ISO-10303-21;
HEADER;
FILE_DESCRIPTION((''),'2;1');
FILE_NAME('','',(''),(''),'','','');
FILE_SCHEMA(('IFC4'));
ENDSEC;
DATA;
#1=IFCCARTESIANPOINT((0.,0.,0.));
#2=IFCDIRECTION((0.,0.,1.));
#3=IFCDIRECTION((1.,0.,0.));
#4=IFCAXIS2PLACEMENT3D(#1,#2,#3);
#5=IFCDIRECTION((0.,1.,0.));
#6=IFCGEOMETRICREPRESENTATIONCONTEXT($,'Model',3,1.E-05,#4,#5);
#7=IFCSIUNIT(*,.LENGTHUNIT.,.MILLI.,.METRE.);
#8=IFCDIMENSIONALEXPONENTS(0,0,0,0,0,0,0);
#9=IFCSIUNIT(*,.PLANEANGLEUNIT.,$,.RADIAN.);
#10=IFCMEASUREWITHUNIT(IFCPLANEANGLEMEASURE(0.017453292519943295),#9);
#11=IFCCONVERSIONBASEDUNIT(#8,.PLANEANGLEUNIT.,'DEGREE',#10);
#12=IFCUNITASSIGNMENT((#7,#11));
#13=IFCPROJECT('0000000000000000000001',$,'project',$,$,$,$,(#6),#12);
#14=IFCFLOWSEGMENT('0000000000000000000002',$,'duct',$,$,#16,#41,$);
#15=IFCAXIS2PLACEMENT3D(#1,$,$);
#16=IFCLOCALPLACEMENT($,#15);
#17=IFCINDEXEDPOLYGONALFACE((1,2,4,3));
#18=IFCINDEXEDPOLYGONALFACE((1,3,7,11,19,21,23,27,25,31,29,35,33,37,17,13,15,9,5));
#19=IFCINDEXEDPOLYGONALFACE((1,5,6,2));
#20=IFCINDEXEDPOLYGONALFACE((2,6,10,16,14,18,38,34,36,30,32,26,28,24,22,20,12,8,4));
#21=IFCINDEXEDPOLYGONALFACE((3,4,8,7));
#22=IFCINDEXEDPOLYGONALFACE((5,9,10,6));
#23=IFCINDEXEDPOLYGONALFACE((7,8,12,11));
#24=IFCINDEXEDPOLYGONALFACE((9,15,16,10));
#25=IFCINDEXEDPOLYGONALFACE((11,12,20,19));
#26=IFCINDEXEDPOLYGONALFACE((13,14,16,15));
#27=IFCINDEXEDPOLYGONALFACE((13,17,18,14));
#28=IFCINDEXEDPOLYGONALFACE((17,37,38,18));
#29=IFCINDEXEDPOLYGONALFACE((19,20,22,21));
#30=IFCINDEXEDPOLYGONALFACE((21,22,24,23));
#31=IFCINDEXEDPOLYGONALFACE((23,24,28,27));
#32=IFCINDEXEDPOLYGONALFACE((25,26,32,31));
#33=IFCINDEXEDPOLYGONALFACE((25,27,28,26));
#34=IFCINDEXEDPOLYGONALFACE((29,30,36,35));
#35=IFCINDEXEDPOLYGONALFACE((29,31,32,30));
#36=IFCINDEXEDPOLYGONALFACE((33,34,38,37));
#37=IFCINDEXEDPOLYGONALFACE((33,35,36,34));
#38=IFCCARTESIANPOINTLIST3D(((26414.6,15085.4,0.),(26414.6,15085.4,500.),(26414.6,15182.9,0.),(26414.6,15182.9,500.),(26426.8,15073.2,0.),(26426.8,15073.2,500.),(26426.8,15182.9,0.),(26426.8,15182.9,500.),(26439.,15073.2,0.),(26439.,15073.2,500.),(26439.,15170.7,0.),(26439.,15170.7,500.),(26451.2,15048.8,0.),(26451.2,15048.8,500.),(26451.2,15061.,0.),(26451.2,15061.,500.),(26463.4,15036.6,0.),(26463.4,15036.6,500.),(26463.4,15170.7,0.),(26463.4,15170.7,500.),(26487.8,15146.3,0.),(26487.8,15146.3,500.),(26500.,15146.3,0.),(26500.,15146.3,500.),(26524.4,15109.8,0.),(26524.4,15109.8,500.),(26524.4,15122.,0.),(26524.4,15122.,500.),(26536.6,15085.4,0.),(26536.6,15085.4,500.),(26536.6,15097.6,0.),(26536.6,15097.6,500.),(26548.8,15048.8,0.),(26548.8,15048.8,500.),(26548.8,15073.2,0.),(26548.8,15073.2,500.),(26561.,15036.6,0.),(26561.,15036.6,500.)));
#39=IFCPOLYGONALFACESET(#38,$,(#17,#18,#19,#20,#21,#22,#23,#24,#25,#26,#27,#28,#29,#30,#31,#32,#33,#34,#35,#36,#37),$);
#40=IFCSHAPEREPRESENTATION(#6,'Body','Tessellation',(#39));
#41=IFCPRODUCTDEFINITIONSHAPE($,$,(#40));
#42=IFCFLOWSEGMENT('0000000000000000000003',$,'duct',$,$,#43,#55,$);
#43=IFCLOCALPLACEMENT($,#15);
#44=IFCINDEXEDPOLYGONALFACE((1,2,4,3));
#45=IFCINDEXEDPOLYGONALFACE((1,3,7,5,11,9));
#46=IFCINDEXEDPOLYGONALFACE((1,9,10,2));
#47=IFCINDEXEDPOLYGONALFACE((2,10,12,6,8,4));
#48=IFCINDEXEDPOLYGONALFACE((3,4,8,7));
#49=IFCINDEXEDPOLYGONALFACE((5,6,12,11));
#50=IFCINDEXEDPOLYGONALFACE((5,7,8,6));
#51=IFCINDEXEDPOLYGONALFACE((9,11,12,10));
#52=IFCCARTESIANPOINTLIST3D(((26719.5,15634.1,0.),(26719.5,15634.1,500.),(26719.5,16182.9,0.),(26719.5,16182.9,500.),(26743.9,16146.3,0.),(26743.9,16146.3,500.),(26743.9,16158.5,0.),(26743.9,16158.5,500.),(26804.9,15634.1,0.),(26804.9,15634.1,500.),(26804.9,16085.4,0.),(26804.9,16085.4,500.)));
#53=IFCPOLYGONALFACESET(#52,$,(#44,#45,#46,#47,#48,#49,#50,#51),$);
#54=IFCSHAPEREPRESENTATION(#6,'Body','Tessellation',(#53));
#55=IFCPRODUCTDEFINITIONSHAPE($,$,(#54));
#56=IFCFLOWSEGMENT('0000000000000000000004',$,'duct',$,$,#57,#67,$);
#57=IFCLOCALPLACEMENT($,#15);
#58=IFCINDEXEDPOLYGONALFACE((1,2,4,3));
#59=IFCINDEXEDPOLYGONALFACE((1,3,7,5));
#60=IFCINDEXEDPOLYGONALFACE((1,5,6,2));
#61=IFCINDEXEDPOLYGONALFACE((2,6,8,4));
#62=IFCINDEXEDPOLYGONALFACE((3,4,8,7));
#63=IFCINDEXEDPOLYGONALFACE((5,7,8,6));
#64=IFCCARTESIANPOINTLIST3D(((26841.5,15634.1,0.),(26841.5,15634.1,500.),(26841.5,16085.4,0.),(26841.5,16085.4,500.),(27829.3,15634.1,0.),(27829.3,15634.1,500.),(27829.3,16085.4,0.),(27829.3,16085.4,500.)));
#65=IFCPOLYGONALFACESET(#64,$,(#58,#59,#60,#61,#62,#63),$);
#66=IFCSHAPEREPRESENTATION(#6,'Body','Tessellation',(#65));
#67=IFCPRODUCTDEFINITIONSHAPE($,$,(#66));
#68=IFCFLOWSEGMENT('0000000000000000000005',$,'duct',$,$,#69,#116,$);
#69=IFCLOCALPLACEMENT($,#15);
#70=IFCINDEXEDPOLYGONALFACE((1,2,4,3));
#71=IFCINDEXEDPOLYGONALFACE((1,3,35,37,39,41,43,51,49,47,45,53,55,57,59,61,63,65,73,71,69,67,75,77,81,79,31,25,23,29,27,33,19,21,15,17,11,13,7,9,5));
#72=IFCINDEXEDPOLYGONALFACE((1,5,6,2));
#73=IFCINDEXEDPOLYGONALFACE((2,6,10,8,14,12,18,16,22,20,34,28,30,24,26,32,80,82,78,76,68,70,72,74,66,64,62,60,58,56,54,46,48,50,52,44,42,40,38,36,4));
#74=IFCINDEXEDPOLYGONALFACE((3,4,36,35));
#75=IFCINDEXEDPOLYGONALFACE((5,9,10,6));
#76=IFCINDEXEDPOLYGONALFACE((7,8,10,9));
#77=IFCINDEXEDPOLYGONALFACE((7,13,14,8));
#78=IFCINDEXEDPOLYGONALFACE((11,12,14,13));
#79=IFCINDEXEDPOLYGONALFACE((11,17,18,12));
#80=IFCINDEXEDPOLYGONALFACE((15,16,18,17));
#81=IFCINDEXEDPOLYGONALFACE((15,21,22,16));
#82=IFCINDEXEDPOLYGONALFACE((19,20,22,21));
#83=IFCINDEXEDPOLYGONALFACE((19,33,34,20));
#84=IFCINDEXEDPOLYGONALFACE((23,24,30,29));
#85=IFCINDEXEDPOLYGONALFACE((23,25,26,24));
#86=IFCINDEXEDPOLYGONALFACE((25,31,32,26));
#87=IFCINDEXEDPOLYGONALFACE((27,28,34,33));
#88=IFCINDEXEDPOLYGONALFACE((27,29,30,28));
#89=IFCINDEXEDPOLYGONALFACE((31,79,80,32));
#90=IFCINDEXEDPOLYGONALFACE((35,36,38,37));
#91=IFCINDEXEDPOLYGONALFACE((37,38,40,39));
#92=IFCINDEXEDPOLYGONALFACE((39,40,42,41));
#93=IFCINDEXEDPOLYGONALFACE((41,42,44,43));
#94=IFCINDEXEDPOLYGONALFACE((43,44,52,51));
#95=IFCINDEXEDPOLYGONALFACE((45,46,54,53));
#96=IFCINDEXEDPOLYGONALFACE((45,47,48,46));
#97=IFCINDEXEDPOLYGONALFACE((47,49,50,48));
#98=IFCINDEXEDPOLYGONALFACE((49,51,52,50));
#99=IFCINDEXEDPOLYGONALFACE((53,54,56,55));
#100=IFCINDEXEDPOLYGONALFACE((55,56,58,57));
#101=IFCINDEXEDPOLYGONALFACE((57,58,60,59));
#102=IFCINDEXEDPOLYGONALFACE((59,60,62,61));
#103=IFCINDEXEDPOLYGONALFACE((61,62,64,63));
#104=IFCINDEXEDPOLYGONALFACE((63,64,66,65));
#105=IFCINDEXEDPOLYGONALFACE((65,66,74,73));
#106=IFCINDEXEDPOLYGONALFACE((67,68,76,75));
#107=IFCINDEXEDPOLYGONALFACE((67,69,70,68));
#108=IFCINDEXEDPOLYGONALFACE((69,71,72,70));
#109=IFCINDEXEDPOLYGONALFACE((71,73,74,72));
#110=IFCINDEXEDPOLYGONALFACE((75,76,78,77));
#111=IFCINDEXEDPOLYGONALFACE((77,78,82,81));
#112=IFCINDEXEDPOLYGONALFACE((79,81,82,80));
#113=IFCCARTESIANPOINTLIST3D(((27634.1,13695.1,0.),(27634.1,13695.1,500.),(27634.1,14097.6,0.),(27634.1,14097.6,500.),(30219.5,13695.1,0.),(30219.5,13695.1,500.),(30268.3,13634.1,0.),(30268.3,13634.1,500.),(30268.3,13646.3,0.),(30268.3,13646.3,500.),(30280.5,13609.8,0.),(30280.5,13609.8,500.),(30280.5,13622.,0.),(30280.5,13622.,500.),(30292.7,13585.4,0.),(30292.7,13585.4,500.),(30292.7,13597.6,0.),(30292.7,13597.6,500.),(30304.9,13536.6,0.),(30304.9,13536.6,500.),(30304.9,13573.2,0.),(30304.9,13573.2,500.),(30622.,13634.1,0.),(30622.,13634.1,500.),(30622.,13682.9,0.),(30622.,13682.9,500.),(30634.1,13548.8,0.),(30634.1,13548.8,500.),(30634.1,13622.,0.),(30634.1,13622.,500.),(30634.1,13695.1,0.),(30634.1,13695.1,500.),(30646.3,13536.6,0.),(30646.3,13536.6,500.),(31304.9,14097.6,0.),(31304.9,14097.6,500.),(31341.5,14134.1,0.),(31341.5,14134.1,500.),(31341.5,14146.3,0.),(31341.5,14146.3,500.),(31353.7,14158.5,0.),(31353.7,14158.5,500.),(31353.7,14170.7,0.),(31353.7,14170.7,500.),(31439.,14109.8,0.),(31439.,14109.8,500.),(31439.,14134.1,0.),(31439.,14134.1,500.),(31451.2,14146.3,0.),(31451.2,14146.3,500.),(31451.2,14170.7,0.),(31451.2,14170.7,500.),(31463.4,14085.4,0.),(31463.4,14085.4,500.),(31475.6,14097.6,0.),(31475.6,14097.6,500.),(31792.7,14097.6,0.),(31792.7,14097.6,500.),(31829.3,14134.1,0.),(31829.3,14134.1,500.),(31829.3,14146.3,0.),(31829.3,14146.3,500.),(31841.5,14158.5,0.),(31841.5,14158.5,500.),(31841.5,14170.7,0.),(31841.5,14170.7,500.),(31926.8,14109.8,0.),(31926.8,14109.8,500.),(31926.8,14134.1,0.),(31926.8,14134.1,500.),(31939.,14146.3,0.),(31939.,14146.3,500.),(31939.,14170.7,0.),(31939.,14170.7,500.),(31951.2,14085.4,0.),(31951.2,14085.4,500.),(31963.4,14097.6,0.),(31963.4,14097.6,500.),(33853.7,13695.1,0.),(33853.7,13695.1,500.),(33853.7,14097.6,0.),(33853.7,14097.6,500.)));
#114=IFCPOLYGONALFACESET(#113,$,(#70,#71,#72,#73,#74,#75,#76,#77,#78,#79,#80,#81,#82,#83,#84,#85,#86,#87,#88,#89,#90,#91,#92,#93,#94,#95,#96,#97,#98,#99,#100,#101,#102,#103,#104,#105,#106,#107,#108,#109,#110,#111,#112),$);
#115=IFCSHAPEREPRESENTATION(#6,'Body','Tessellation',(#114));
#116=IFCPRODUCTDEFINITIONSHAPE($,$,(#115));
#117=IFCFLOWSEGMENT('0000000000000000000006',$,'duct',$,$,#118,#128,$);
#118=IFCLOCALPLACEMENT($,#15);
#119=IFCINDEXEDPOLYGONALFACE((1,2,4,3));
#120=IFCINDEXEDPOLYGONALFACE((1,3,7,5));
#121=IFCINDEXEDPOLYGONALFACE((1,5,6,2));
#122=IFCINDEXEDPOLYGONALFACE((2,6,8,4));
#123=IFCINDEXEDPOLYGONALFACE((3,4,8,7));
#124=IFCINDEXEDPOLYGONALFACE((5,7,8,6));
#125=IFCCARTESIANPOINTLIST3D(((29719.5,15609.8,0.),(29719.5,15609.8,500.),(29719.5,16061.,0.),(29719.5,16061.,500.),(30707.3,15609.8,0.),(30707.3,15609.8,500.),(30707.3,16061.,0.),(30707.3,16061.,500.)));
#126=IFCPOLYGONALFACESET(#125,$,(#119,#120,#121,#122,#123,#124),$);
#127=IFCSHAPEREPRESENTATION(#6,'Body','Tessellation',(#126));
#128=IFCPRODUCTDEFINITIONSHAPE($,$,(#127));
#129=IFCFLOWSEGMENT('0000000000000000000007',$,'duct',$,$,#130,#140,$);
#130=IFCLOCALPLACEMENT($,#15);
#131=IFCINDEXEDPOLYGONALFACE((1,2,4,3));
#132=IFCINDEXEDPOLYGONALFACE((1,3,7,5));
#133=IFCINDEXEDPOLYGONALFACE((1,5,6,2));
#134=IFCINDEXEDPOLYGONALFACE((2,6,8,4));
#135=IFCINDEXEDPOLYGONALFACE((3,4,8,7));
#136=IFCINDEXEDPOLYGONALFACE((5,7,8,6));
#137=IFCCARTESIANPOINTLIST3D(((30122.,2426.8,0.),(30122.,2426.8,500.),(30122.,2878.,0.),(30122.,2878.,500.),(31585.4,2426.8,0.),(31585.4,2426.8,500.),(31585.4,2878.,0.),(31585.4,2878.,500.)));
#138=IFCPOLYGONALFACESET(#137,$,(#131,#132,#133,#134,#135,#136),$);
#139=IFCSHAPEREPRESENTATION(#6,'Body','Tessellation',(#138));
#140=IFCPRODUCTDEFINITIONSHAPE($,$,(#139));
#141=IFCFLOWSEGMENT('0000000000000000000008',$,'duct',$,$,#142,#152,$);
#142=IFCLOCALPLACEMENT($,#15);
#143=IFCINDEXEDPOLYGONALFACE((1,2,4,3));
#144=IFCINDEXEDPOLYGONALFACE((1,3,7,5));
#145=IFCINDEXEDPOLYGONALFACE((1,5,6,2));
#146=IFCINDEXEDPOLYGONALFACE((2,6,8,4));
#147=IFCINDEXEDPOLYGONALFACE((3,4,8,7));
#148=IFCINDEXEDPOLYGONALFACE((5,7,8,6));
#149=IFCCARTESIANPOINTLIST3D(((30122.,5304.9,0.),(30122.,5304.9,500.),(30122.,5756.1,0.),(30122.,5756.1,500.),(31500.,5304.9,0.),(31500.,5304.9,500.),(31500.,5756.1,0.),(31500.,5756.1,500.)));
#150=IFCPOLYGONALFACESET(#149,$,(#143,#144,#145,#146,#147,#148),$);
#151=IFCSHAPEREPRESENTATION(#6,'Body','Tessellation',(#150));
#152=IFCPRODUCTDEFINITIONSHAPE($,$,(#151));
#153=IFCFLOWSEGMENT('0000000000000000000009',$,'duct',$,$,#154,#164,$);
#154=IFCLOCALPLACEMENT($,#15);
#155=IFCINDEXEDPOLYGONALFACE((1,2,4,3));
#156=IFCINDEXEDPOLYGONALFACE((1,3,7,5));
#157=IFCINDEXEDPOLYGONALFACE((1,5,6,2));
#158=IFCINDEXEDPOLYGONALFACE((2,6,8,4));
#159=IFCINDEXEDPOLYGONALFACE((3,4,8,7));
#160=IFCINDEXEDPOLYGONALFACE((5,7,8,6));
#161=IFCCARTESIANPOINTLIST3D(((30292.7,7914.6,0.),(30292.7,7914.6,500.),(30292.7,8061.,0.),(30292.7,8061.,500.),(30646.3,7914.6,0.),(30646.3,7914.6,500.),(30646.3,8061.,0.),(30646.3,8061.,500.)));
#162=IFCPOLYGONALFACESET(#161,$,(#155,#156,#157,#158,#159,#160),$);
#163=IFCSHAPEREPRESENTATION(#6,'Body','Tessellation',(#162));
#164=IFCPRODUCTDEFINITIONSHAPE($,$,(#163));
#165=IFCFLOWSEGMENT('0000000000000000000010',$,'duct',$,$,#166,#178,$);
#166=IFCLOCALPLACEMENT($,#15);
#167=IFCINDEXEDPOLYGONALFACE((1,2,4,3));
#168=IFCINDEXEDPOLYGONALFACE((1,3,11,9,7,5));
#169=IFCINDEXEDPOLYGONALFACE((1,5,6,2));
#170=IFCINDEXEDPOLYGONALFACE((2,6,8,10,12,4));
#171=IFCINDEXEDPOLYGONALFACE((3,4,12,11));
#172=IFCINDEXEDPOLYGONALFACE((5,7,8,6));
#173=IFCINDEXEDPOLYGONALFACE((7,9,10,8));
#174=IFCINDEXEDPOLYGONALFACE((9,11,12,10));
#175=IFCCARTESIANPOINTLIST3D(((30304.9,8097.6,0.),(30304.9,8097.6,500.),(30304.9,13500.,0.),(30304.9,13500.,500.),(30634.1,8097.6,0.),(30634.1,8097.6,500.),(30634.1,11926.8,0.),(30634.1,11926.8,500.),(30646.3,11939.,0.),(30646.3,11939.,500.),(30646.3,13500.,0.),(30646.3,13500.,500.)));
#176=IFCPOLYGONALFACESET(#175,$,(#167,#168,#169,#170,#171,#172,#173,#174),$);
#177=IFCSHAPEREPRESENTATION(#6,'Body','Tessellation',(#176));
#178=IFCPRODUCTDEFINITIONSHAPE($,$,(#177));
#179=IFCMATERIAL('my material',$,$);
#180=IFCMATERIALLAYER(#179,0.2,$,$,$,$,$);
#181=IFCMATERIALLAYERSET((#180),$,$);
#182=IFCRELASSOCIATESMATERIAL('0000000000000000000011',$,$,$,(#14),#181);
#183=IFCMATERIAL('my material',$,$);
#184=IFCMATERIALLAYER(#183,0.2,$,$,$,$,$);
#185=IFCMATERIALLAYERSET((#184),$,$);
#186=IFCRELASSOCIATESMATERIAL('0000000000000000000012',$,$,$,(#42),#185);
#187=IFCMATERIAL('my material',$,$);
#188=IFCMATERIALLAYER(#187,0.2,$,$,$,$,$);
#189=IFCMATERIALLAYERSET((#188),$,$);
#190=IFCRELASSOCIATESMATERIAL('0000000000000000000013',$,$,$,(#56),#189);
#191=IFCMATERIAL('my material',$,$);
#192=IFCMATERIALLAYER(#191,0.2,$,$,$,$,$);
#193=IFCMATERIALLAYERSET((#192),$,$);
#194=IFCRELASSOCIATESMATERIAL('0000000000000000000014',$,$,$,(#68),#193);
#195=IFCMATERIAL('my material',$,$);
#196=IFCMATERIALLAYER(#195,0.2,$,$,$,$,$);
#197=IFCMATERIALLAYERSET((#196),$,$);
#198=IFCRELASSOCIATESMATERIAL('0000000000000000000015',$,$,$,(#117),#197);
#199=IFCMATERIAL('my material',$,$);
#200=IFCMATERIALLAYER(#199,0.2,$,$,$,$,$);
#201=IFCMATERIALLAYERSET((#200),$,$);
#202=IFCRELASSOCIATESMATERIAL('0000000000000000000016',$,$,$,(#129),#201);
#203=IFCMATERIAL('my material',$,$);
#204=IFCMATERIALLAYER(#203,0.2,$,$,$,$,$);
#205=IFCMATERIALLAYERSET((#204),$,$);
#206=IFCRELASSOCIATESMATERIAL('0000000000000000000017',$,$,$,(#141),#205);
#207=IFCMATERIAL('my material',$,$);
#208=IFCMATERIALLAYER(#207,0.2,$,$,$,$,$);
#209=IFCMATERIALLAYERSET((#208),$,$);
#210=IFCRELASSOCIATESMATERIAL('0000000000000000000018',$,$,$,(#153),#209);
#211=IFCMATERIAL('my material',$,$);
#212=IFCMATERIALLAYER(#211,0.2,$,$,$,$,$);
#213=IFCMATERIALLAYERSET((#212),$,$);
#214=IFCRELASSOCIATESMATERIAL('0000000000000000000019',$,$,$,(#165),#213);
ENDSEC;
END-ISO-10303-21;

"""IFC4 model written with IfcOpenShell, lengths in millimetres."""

from ifc_helpers import new_model, entity, si_unit, converted_unit, direction, origin_with_axes, place, context, project, polyline, outline, extrude, material, layer, layer_set, layer_usage, element, save


model = new_model("IFC4")

# Units and contexts
model_context = context("Model", 3, precision=1e-05, world=origin_with_axes(), true_north=direction((0.0, 1.0, 0.0)))
ifc_project = project(units=[si_unit("LENGTHUNIT", "METRE", prefix="MILLI"), converted_unit("PLANEANGLEUNIT", "DEGREE", entity("IfcPlaneAngleMeasure", 0.017453292519943295), si_unit("PLANEANGLEUNIT", "RADIAN"), dimensions=[0, 0, 0, 0, 0, 0, 0])], contexts=[model_context])

# Flow segments
ifc_material_1 = material(Name="my material")
ifc_layer_1 = layer(ifc_material_1, 0.2)
ifc_layer_set_1 = layer_set([ifc_layer_1])
ifc_layer_usage_1 = layer_usage(ifc_layer_set_1, "AXIS2", "POSITIVE", -0.1)
flow_segment_1_placement = place(None, origin_with_axes())
element("IfcFlowSegment", 1, at=flow_segment_1_placement, material=ifc_layer_usage_1, Name="duct", context=model_context, shape_type="SweptSolid", body=[
    extrude(outline(polyline([(26414.6, 15085.4), (26426.8, 15073.2), (26439.0, 15073.2), (26451.2, 15061.0), (26451.2, 15048.8), (26463.4, 15036.6), (26561.0, 15036.6), (26548.8, 15048.8), (26548.8, 15073.2), (26536.6, 15085.4), (26536.6, 15097.6), (26524.4, 15109.8), (26524.4, 15122.0), (26500.0, 15146.3), (26487.8, 15146.3), (26463.4, 15170.7), (26439.0, 15170.7), (26426.8, 15182.9), (26414.6, 15182.9), (26414.6, 15085.4)])), origin_with_axes(), (0.0, 0.0, 1.0), 500.0),
])
ifc_material_2 = material(Name="my material")
ifc_layer_2 = layer(ifc_material_2, 0.2)
ifc_layer_set_2 = layer_set([ifc_layer_2])
ifc_layer_usage_2 = layer_usage(ifc_layer_set_2, "AXIS2", "POSITIVE", -0.1)
flow_segment_2_placement = place(None, origin_with_axes())
element("IfcFlowSegment", 2, at=flow_segment_2_placement, material=ifc_layer_usage_2, Name="duct", context=model_context, shape_type="SweptSolid", body=[
    extrude(outline(polyline([(26719.5, 15634.1), (26804.9, 15634.1), (26804.9, 16085.4), (26743.9, 16146.3), (26743.9, 16158.5), (26719.5, 16182.9), (26719.5, 15634.1)])), origin_with_axes(), (0.0, 0.0, 1.0), 500.0),
])
ifc_material_3 = material(Name="my material")
ifc_layer_3 = layer(ifc_material_3, 0.2)
ifc_layer_set_3 = layer_set([ifc_layer_3])
ifc_layer_usage_3 = layer_usage(ifc_layer_set_3, "AXIS2", "POSITIVE", -0.1)
flow_segment_3_placement = place(None, origin_with_axes())
element("IfcFlowSegment", 3, at=flow_segment_3_placement, material=ifc_layer_usage_3, Name="duct", context=model_context, shape_type="SweptSolid", body=[
    extrude(outline(polyline([(26841.5, 15634.1), (27829.3, 15634.1), (27829.3, 16085.4), (26841.5, 16085.4), (26841.5, 15634.1)])), origin_with_axes(), (0.0, 0.0, 1.0), 500.0),
])
ifc_material_4 = material(Name="my material")
ifc_layer_4 = layer(ifc_material_4, 0.2)
ifc_layer_set_4 = layer_set([ifc_layer_4])
ifc_layer_usage_4 = layer_usage(ifc_layer_set_4, "AXIS2", "POSITIVE", -0.1)
flow_segment_4_placement = place(None, origin_with_axes())
element("IfcFlowSegment", 4, at=flow_segment_4_placement, material=ifc_layer_usage_4, Name="duct", context=model_context, shape_type="SweptSolid", body=[
    extrude(outline(polyline([(27634.1, 13695.1), (30219.5, 13695.1), (30268.3, 13646.3), (30268.3, 13634.1), (30280.5, 13622.0), (30280.5, 13609.8), (30292.7, 13597.6), (30292.7, 13585.4), (30304.9, 13573.2), (30304.9, 13536.6), (30646.3, 13536.6), (30634.1, 13548.8), (30634.1, 13622.0), (30622.0, 13634.1), (30622.0, 13682.9), (30634.1, 13695.1), (33853.7, 13695.1), (33853.7, 14097.6), (31963.4, 14097.6), (31951.2, 14085.4), (31926.8, 14109.8), (31926.8, 14134.1), (31939.0, 14146.3), (31939.0, 14170.7), (31841.5, 14170.7), (31841.5, 14158.5), (31829.3, 14146.3), (31829.3, 14134.1), (31792.7, 14097.6), (31475.6, 14097.6), (31463.4, 14085.4), (31439.0, 14109.8), (31439.0, 14134.1), (31451.2, 14146.3), (31451.2, 14170.7), (31353.7, 14170.7), (31353.7, 14158.5), (31341.5, 14146.3), (31341.5, 14134.1), (31304.9, 14097.6), (27634.1, 14097.6), (27634.1, 13695.1)])), origin_with_axes(), (0.0, 0.0, 1.0), 500.0),
])
ifc_material_5 = material(Name="my material")
ifc_layer_5 = layer(ifc_material_5, 0.2)
ifc_layer_set_5 = layer_set([ifc_layer_5])
ifc_layer_usage_5 = layer_usage(ifc_layer_set_5, "AXIS2", "POSITIVE", -0.1)
flow_segment_5_placement = place(None, origin_with_axes())
element("IfcFlowSegment", 5, at=flow_segment_5_placement, material=ifc_layer_usage_5, Name="duct", context=model_context, shape_type="SweptSolid", body=[
    extrude(outline(polyline([(29719.5, 15609.8), (30707.3, 15609.8), (30707.3, 16061.0), (29719.5, 16061.0), (29719.5, 15609.8)])), origin_with_axes(), (0.0, 0.0, 1.0), 500.0),
])
ifc_material_6 = material(Name="my material")
ifc_layer_6 = layer(ifc_material_6, 0.2)
ifc_layer_set_6 = layer_set([ifc_layer_6])
ifc_layer_usage_6 = layer_usage(ifc_layer_set_6, "AXIS2", "POSITIVE", -0.1)
flow_segment_6_placement = place(None, origin_with_axes())
element("IfcFlowSegment", 6, at=flow_segment_6_placement, material=ifc_layer_usage_6, Name="duct", context=model_context, shape_type="SweptSolid", body=[
    extrude(outline(polyline([(30122.0, 2426.8), (31585.4, 2426.8), (31585.4, 2878.0), (30122.0, 2878.0), (30122.0, 2426.8)])), origin_with_axes(), (0.0, 0.0, 1.0), 500.0),
])
ifc_material_7 = material(Name="my material")
ifc_layer_7 = layer(ifc_material_7, 0.2)
ifc_layer_set_7 = layer_set([ifc_layer_7])
ifc_layer_usage_7 = layer_usage(ifc_layer_set_7, "AXIS2", "POSITIVE", -0.1)
flow_segment_7_placement = place(None, origin_with_axes())
element("IfcFlowSegment", 7, at=flow_segment_7_placement, material=ifc_layer_usage_7, Name="duct", context=model_context, shape_type="SweptSolid", body=[
    extrude(outline(polyline([(30122.0, 5304.9), (31500.0, 5304.9), (31500.0, 5756.1), (30122.0, 5756.1), (30122.0, 5304.9)])), origin_with_axes(), (0.0, 0.0, 1.0), 500.0),
])
ifc_material_8 = material(Name="my material")
ifc_layer_8 = layer(ifc_material_8, 0.2)
ifc_layer_set_8 = layer_set([ifc_layer_8])
ifc_layer_usage_8 = layer_usage(ifc_layer_set_8, "AXIS2", "POSITIVE", -0.1)
flow_segment_8_placement = place(None, origin_with_axes())
element("IfcFlowSegment", 8, at=flow_segment_8_placement, material=ifc_layer_usage_8, Name="duct", context=model_context, shape_type="SweptSolid", body=[
    extrude(outline(polyline([(30292.7, 7914.6), (30646.3, 7914.6), (30646.3, 8061.0), (30292.7, 8061.0), (30292.7, 7914.6)])), origin_with_axes(), (0.0, 0.0, 1.0), 500.0),
])
ifc_material_9 = material(Name="my material")
ifc_layer_9 = layer(ifc_material_9, 0.2)
ifc_layer_set_9 = layer_set([ifc_layer_9])
ifc_layer_usage_9 = layer_usage(ifc_layer_set_9, "AXIS2", "POSITIVE", -0.1)
flow_segment_9_placement = place(None, origin_with_axes())
element("IfcFlowSegment", 9, at=flow_segment_9_placement, material=ifc_layer_usage_9, Name="duct", context=model_context, shape_type="SweptSolid", body=[
    extrude(outline(polyline([(30304.9, 8097.6), (30634.1, 8097.6), (30634.1, 11926.8), (30646.3, 11939.0), (30646.3, 13500.0), (30304.9, 13500.0), (30304.9, 8097.6)])), origin_with_axes(), (0.0, 0.0, 1.0), 500.0),
])

save(model, "model.ifc")
